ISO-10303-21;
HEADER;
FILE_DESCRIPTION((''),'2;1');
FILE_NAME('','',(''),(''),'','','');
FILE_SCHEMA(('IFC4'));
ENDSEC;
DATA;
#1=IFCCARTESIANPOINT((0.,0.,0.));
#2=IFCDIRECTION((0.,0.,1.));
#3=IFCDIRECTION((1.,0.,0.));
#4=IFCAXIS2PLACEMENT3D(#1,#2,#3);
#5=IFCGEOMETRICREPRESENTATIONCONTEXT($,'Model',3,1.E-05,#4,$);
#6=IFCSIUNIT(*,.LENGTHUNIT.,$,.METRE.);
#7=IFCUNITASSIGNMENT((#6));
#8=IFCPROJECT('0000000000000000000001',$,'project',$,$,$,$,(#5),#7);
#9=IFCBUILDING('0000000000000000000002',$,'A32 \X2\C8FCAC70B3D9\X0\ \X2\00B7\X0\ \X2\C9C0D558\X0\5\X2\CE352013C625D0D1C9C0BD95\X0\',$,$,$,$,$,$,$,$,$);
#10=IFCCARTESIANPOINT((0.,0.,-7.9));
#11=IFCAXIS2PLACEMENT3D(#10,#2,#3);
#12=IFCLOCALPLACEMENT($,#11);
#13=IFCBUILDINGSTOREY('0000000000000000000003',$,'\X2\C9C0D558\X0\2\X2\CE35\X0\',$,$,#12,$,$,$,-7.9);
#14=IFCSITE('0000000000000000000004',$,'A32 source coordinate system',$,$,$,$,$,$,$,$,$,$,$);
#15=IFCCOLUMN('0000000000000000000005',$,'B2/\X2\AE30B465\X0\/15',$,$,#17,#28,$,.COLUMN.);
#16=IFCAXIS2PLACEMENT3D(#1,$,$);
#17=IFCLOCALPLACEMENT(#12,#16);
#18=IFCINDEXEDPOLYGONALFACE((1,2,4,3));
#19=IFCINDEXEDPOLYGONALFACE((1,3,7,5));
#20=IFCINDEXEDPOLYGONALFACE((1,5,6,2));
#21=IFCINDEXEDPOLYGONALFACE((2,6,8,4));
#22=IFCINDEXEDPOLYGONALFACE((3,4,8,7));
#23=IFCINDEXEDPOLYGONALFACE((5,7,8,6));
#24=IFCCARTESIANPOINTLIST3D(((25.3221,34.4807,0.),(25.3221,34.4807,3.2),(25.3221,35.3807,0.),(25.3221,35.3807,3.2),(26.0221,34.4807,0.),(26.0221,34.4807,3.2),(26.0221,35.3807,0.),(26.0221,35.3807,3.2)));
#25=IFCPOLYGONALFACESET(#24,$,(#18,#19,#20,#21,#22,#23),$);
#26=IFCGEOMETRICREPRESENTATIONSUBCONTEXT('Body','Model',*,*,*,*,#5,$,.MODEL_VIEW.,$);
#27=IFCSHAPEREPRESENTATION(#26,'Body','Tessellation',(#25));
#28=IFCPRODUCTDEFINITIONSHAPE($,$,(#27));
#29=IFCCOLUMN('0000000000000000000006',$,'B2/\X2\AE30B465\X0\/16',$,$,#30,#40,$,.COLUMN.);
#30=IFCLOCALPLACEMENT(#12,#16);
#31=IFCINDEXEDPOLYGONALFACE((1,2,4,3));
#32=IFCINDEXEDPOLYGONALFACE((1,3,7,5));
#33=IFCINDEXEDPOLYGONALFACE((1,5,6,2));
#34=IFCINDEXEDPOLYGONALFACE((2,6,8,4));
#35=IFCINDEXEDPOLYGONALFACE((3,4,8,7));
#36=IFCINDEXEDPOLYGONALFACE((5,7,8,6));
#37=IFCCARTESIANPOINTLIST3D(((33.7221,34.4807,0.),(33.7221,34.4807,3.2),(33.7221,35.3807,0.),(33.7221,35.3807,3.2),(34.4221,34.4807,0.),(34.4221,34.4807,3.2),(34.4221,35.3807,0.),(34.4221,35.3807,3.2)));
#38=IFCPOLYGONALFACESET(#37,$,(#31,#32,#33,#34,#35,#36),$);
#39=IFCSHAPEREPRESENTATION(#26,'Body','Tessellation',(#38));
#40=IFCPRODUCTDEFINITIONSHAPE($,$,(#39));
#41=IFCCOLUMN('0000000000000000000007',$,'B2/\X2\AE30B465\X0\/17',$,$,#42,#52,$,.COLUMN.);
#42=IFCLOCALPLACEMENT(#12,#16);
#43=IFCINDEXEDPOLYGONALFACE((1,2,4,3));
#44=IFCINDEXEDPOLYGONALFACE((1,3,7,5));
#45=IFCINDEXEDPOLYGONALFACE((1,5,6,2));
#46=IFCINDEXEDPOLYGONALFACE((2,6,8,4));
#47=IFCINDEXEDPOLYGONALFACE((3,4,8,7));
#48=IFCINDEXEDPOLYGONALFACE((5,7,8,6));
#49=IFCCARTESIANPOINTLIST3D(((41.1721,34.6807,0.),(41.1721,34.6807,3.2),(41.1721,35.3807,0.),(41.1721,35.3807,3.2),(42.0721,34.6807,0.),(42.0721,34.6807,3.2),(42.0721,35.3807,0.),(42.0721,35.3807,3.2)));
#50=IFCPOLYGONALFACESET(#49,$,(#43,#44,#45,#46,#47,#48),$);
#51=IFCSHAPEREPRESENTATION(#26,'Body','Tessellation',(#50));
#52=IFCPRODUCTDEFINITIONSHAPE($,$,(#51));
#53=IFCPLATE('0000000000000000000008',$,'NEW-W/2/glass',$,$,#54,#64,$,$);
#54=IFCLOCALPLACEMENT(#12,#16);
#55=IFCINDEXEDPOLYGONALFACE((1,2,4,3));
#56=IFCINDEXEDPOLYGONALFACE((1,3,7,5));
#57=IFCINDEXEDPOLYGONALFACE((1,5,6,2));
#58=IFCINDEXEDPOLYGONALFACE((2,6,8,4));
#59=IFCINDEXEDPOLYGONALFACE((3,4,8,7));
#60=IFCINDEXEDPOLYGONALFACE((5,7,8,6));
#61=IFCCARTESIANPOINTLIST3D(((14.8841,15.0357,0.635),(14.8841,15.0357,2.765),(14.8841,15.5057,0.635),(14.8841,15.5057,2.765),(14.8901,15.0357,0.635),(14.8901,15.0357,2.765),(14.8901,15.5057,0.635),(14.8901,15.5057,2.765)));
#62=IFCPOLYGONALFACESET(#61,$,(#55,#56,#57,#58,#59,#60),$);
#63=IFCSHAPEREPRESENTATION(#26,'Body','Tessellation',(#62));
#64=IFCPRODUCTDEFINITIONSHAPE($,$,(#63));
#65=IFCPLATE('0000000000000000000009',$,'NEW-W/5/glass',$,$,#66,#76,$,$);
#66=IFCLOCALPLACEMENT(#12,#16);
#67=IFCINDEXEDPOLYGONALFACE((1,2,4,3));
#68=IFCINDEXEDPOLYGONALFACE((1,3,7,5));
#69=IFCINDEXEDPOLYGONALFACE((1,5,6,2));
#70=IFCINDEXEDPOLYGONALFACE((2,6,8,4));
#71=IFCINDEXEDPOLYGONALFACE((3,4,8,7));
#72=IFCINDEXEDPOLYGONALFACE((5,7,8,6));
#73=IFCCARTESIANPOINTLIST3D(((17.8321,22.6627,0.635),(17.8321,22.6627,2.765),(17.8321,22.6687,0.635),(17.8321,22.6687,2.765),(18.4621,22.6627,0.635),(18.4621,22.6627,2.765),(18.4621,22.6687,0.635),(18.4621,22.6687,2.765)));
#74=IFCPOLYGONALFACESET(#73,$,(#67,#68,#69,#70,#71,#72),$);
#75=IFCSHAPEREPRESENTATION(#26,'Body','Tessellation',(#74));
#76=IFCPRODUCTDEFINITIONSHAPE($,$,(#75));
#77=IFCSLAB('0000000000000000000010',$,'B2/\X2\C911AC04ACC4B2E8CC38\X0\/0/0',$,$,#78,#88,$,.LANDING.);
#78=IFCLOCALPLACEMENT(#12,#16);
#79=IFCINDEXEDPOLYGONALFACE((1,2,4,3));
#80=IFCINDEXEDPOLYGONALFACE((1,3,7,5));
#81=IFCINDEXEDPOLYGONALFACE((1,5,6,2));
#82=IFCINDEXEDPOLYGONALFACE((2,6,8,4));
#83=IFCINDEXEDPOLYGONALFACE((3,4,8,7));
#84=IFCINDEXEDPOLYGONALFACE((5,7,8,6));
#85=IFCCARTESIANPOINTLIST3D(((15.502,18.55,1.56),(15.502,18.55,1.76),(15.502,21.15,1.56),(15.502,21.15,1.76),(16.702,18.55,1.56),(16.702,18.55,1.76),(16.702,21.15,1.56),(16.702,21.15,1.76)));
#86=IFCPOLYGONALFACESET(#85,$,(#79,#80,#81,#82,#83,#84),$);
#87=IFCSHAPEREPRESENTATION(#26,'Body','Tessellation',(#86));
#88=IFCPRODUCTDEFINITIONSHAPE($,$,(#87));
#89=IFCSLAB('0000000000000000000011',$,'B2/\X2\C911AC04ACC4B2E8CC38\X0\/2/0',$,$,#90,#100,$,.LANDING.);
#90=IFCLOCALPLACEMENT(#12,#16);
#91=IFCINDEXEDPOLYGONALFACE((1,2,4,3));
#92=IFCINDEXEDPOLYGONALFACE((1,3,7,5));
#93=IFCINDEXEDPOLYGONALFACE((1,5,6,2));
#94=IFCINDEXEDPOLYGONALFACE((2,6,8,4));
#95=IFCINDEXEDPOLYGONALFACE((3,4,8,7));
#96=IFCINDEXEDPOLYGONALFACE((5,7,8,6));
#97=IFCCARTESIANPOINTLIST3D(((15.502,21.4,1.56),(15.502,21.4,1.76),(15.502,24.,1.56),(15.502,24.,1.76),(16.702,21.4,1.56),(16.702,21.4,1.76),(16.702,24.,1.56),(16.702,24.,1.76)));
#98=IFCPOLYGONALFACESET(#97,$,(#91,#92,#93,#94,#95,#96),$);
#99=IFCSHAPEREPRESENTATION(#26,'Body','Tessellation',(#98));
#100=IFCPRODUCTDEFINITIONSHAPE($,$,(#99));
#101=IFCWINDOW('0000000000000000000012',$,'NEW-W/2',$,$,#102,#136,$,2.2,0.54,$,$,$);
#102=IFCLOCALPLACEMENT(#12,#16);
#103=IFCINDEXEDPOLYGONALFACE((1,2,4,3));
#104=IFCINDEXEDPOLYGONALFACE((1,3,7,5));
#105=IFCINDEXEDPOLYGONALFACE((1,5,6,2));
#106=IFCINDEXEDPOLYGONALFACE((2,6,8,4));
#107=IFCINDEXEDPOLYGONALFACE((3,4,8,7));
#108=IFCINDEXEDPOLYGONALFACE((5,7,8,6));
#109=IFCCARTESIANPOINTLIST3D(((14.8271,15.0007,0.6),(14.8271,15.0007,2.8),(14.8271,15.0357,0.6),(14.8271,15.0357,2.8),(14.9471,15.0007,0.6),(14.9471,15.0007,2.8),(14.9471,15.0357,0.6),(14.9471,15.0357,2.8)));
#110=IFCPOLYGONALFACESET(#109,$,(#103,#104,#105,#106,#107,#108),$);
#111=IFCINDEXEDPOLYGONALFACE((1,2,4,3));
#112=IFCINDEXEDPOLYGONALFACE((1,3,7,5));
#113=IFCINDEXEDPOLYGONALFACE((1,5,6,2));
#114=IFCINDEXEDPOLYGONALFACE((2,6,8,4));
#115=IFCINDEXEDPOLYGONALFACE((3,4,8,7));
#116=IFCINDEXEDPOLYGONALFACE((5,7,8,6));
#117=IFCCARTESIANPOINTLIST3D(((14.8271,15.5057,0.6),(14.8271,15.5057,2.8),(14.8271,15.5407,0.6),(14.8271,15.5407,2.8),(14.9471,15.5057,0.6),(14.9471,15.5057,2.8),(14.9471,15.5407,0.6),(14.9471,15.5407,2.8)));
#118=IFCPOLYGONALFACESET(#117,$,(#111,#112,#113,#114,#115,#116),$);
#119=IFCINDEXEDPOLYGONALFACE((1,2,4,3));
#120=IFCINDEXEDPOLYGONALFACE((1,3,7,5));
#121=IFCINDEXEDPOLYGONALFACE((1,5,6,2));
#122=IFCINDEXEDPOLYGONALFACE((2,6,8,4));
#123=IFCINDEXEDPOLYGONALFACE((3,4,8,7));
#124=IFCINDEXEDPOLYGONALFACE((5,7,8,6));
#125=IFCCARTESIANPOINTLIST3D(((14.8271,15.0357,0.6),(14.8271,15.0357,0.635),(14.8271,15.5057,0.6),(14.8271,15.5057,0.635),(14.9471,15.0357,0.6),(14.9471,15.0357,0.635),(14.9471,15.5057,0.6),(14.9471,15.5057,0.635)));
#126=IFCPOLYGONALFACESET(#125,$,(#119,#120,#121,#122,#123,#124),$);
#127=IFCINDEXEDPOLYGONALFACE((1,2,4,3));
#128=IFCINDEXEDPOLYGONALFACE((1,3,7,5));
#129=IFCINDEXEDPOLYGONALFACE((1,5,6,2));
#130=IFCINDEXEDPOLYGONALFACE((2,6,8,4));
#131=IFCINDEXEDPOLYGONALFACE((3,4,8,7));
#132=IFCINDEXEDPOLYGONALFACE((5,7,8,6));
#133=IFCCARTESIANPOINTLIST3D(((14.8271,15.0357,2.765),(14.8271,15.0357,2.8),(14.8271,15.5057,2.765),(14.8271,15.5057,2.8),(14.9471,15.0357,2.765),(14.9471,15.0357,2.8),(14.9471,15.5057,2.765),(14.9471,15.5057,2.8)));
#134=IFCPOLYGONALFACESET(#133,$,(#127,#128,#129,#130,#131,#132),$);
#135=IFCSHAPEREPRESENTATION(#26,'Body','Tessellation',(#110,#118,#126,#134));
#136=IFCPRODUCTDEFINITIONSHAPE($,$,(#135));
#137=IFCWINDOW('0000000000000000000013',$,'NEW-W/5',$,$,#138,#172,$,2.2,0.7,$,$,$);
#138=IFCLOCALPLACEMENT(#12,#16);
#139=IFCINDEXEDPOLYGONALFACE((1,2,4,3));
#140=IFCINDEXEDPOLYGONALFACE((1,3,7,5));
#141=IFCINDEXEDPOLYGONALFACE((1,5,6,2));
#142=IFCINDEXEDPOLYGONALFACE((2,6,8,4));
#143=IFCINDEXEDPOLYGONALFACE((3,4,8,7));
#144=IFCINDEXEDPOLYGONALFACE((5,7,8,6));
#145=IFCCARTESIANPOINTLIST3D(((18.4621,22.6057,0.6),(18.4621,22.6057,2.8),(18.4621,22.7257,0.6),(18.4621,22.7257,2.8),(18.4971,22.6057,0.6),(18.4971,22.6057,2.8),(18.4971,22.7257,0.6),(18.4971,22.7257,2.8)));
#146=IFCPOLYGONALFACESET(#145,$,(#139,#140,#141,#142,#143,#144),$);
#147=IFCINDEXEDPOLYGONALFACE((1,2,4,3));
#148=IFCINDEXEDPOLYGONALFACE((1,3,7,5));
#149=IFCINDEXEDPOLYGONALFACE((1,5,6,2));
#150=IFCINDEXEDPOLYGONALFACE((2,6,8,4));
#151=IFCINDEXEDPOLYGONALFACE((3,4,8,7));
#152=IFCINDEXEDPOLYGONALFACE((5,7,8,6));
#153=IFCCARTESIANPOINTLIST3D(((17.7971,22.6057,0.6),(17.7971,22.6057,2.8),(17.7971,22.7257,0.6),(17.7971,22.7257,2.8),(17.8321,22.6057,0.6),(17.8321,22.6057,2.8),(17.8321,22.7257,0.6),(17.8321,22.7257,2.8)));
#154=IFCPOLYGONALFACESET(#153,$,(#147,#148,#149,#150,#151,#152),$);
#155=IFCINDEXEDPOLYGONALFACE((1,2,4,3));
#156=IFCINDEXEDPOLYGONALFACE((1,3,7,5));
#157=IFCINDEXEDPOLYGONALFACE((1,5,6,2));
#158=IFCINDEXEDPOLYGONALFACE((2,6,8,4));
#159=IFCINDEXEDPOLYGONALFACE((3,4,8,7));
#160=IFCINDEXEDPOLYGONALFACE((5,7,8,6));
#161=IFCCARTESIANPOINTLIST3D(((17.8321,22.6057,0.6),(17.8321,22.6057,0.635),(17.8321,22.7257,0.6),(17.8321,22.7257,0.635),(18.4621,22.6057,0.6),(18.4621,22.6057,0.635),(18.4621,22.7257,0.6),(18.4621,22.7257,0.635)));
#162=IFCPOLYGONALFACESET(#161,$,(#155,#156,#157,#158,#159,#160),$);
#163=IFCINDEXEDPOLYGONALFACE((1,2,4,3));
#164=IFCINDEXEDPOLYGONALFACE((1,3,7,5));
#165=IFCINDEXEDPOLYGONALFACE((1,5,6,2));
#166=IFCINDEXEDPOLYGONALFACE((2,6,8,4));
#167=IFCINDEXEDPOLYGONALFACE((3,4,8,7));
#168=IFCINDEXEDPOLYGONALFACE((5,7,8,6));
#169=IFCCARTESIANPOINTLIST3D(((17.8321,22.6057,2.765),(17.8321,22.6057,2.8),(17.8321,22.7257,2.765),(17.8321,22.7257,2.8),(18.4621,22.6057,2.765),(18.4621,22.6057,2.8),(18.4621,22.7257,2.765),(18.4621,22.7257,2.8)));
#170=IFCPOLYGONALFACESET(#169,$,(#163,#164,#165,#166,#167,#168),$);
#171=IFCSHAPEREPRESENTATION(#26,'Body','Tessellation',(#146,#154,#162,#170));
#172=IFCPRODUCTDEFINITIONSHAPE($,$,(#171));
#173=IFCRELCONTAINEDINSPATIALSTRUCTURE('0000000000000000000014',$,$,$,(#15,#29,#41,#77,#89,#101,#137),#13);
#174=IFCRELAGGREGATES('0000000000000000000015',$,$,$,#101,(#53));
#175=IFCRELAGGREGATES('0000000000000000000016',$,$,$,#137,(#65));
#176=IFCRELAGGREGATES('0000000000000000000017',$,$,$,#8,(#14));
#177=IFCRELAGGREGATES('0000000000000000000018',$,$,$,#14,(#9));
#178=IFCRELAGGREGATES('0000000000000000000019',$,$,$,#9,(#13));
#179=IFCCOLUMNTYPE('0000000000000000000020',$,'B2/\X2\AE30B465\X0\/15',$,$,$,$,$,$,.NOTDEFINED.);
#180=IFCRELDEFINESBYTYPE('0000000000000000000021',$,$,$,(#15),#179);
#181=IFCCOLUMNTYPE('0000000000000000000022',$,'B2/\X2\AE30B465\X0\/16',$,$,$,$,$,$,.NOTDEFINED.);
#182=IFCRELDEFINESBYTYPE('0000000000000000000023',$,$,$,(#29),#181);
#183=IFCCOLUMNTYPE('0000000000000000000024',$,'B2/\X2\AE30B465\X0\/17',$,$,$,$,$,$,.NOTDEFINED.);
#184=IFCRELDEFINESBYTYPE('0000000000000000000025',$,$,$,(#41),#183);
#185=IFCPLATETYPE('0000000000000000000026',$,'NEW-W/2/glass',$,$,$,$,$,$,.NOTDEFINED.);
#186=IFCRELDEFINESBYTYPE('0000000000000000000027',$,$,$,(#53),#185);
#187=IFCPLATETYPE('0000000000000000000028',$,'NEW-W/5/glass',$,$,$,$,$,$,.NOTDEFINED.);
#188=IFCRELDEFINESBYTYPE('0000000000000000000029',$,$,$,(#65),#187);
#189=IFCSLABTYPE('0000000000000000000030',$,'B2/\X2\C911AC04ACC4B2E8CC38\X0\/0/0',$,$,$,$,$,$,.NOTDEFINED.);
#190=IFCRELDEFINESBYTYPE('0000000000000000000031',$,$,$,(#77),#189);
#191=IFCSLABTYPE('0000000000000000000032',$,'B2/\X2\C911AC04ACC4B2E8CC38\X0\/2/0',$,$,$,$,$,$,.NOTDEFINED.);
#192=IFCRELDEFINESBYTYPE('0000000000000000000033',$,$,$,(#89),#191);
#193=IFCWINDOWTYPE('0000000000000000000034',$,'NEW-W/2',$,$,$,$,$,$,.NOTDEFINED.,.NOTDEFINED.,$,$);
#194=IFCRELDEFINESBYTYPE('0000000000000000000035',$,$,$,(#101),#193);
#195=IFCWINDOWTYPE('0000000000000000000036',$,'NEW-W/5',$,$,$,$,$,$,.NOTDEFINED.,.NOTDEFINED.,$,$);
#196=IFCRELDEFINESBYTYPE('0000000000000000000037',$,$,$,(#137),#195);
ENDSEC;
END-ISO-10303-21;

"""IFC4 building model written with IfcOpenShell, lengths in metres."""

from ifc_helpers import new_model, si_unit, frame, origin, origin_with_axes, place, context, subcontext, project, spatial, polyline, outline, extrude, source, transform, mapped, type_object, type_shapes, element, aggregate, save


model = new_model("IFC4")

# Units and contexts
model_context = context("Model", 3, precision=1e-05, world=origin_with_axes())
body_context = subcontext(model_context, "Body", "Model", "MODEL_VIEW")
ifc_project = project(units=[si_unit("LENGTHUNIT", "METRE")], contexts=[model_context])

# Site, building, storey
site = spatial("IfcSite", under=ifc_project, Name="A32 source coordinate system")
building = spatial("IfcBuilding", under=site, Name="A32 주거동 · 지하5층–옥탑지붕")
storey_placement = place(None, frame((0.0, 0.0, -7.9), z_axis=(0.0, 0.0, 1.0), x_axis=(1.0, 0.0, 0.0)))
storey = spatial("IfcBuildingStorey", under=building, at=storey_placement, Name="지하2층", Elevation=-7.9)

# Columns
column_type_1 = type_object("IfcColumnType", Name="B2/기둥/15", PredefinedType="NOTDEFINED")
shared_shape_1 = source(origin(), body_context, "Body", "SweptSolid", [
    extrude(outline(polyline([(26.0221, 34.4807), (25.3221, 34.4807), (25.3221, 35.3807), (26.0221, 35.3807), (26.0221, 34.4807)])), origin(), (0.0, 0.0, 1.0), 3.2),
])
type_shapes(column_type_1, [shared_shape_1])
column_1_placement = place(storey_placement, origin_with_axes())
element("IfcColumn", 1, at=column_1_placement, inside=storey, type_object=column_type_1, Name="B2/기둥/15", PredefinedType="COLUMN", context=body_context, shape_type="MappedRepresentation", body=[
    mapped(shared_shape_1, transform((0.0, 0.0, 0.0), scale=1.0)),
])
column_type_2 = type_object("IfcColumnType", Name="B2/기둥/16", PredefinedType="NOTDEFINED")
shared_shape_2 = source(origin(), body_context, "Body", "SweptSolid", [
    extrude(outline(polyline([(34.4221, 34.4807), (33.7221, 34.4807), (33.7221, 35.3807), (34.4221, 35.3807), (34.4221, 34.4807)])), origin(), (0.0, 0.0, 1.0), 3.2),
])
type_shapes(column_type_2, [shared_shape_2])
column_2_placement = place(storey_placement, origin_with_axes())
element("IfcColumn", 2, at=column_2_placement, inside=storey, type_object=column_type_2, Name="B2/기둥/16", PredefinedType="COLUMN", context=body_context, shape_type="MappedRepresentation", body=[
    mapped(shared_shape_2, transform((0.0, 0.0, 0.0), scale=1.0)),
])
column_type_3 = type_object("IfcColumnType", Name="B2/기둥/17", PredefinedType="NOTDEFINED")
shared_shape_3 = source(origin(), body_context, "Body", "SweptSolid", [
    extrude(outline(polyline([(42.0721, 35.3807), (42.0721, 34.6807), (41.1721, 34.6807), (41.1721, 35.3807), (42.0721, 35.3807)])), origin(), (0.0, 0.0, 1.0), 3.2),
])
type_shapes(column_type_3, [shared_shape_3])
column_3_placement = place(storey_placement, origin_with_axes())
element("IfcColumn", 3, at=column_3_placement, inside=storey, type_object=column_type_3, Name="B2/기둥/17", PredefinedType="COLUMN", context=body_context, shape_type="MappedRepresentation", body=[
    mapped(shared_shape_3, transform((0.0, 0.0, 0.0), scale=1.0)),
])

# Plates
plate_type_1 = type_object("IfcPlateType", Name="NEW-W/2/glass", PredefinedType="NOTDEFINED")
shared_shape_4 = source(origin(), body_context, "Body", "SweptSolid", [
    extrude(outline(polyline([(14.8901, 15.0357), (14.8841, 15.0357), (14.8841, 15.5057), (14.8901, 15.5057), (14.8901, 15.0357)])), frame((0.0, 0.0, 0.635)), (0.0, 0.0, 1.0), 2.13),
])
type_shapes(plate_type_1, [shared_shape_4])
window_1_placement = place(storey_placement, origin_with_axes())
plate_1_placement = place(window_1_placement, origin_with_axes())
plate_1 = element("IfcPlate", 4, at=plate_1_placement, type_object=plate_type_1, Name="NEW-W/2/glass", context=body_context, shape_type="MappedRepresentation", body=[
    mapped(shared_shape_4, transform((0.0, 0.0, 0.0), scale=1.0)),
])
plate_type_2 = type_object("IfcPlateType", Name="NEW-W/5/glass", PredefinedType="NOTDEFINED")
shared_shape_5 = source(origin(), body_context, "Body", "SweptSolid", [
    extrude(outline(polyline([(18.4621, 22.6627), (17.8321, 22.6627), (17.8321, 22.6687), (18.4621, 22.6687), (18.4621, 22.6627)])), frame((0.0, 0.0, 0.635)), (0.0, 0.0, 1.0), 2.13),
])
type_shapes(plate_type_2, [shared_shape_5])
window_2_placement = place(storey_placement, origin_with_axes())
plate_2_placement = place(window_2_placement, origin_with_axes())
plate_2 = element("IfcPlate", 5, at=plate_2_placement, type_object=plate_type_2, Name="NEW-W/5/glass", context=body_context, shape_type="MappedRepresentation", body=[
    mapped(shared_shape_5, transform((0.0, 0.0, 0.0), scale=1.0)),
])

# Slabs
slab_type_1 = type_object("IfcSlabType", Name="B2/중간계단참/0/0", PredefinedType="NOTDEFINED")
shared_shape_6 = source(origin(), body_context, "Body", "SweptSolid", [
    extrude(outline(polyline([(16.702, 18.55), (15.502, 18.55), (15.502, 21.15), (16.702, 21.15), (16.702, 18.55)])), frame((0.0, 0.0, 1.56)), (0.0, 0.0, 1.0), 0.2),
])
type_shapes(slab_type_1, [shared_shape_6])
slab_1_placement = place(storey_placement, origin_with_axes())
element("IfcSlab", 6, at=slab_1_placement, inside=storey, type_object=slab_type_1, Name="B2/중간계단참/0/0", PredefinedType="LANDING", context=body_context, shape_type="MappedRepresentation", body=[
    mapped(shared_shape_6, transform((0.0, 0.0, 0.0), scale=1.0)),
])
slab_type_2 = type_object("IfcSlabType", Name="B2/중간계단참/2/0", PredefinedType="NOTDEFINED")
shared_shape_7 = source(origin(), body_context, "Body", "SweptSolid", [
    extrude(outline(polyline([(16.702, 21.4), (15.502, 21.4), (15.502, 24.0), (16.702, 24.0), (16.702, 21.4)])), frame((0.0, 0.0, 1.56)), (0.0, 0.0, 1.0), 0.2),
])
type_shapes(slab_type_2, [shared_shape_7])
slab_2_placement = place(storey_placement, origin_with_axes())
element("IfcSlab", 7, at=slab_2_placement, inside=storey, type_object=slab_type_2, Name="B2/중간계단참/2/0", PredefinedType="LANDING", context=body_context, shape_type="MappedRepresentation", body=[
    mapped(shared_shape_7, transform((0.0, 0.0, 0.0), scale=1.0)),
])

# Windows
window_type_1 = type_object("IfcWindowType", Name="NEW-W/2", PartitioningType="NOTDEFINED", PredefinedType="NOTDEFINED")
shared_shape_8 = source(origin(), body_context, "Body", "SweptSolid", [
    extrude(outline(polyline([(14.8271, 15.0007), (14.8271, 15.0357), (14.9471, 15.0357), (14.9471, 15.0007), (14.8271, 15.0007)])), frame((0.0, 0.0, 0.6)), (0.0, 0.0, 1.0), 2.2),
    extrude(outline(polyline([(14.8271, 15.5057), (14.8271, 15.5407), (14.9471, 15.5407), (14.9471, 15.5057), (14.8271, 15.5057)])), frame((0.0, 0.0, 0.6)), (0.0, 0.0, 1.0), 2.2),
    extrude(outline(polyline([(14.9471, 15.0357), (14.9471, 15.5057), (14.8271, 15.5057), (14.8271, 15.0357), (14.9471, 15.0357)])), frame((0.0, 0.0, 0.6)), (0.0, 0.0, 1.0), 0.035),
    extrude(outline(polyline([(14.9471, 15.0357), (14.9471, 15.5057), (14.8271, 15.5057), (14.8271, 15.0357), (14.9471, 15.0357)])), frame((0.0, 0.0, 2.765)), (0.0, 0.0, 1.0), 0.035),
])
type_shapes(window_type_1, [shared_shape_8])
window_1 = element("IfcWindow", 8, at=window_1_placement, inside=storey, type_object=window_type_1, Name="NEW-W/2", OverallHeight=2.2, OverallWidth=0.54, context=body_context, shape_type="MappedRepresentation", body=[
    mapped(shared_shape_8, transform((0.0, 0.0, 0.0), scale=1.0)),
])
aggregate(window_1, [plate_1])
window_type_2 = type_object("IfcWindowType", Name="NEW-W/5", PartitioningType="NOTDEFINED", PredefinedType="NOTDEFINED")
shared_shape_9 = source(origin(), body_context, "Body", "SweptSolid", [
    extrude(outline(polyline([(18.4621, 22.6057), (18.4621, 22.7257), (18.4971, 22.7257), (18.4971, 22.6057), (18.4621, 22.6057)])), frame((0.0, 0.0, 0.6)), (0.0, 0.0, 1.0), 2.2),
    extrude(outline(polyline([(17.7971, 22.6057), (17.7971, 22.7257), (17.8321, 22.7257), (17.8321, 22.6057), (17.7971, 22.6057)])), frame((0.0, 0.0, 0.6)), (0.0, 0.0, 1.0), 2.2),
    extrude(outline(polyline([(18.4621, 22.6057), (18.4621, 22.7257), (17.8321, 22.7257), (17.8321, 22.6057), (18.4621, 22.6057)])), frame((0.0, 0.0, 0.6)), (0.0, 0.0, 1.0), 0.035),
    extrude(outline(polyline([(18.4621, 22.6057), (18.4621, 22.7257), (17.8321, 22.7257), (17.8321, 22.6057), (18.4621, 22.6057)])), frame((0.0, 0.0, 2.765)), (0.0, 0.0, 1.0), 0.035),
])
type_shapes(window_type_2, [shared_shape_9])
window_2 = element("IfcWindow", 9, at=window_2_placement, inside=storey, type_object=window_type_2, Name="NEW-W/5", OverallHeight=2.2, OverallWidth=0.7, context=body_context, shape_type="MappedRepresentation", body=[
    mapped(shared_shape_9, transform((0.0, 0.0, 0.0), scale=1.0)),
])
aggregate(window_2, [plate_2])

save(model, "model.ifc")
